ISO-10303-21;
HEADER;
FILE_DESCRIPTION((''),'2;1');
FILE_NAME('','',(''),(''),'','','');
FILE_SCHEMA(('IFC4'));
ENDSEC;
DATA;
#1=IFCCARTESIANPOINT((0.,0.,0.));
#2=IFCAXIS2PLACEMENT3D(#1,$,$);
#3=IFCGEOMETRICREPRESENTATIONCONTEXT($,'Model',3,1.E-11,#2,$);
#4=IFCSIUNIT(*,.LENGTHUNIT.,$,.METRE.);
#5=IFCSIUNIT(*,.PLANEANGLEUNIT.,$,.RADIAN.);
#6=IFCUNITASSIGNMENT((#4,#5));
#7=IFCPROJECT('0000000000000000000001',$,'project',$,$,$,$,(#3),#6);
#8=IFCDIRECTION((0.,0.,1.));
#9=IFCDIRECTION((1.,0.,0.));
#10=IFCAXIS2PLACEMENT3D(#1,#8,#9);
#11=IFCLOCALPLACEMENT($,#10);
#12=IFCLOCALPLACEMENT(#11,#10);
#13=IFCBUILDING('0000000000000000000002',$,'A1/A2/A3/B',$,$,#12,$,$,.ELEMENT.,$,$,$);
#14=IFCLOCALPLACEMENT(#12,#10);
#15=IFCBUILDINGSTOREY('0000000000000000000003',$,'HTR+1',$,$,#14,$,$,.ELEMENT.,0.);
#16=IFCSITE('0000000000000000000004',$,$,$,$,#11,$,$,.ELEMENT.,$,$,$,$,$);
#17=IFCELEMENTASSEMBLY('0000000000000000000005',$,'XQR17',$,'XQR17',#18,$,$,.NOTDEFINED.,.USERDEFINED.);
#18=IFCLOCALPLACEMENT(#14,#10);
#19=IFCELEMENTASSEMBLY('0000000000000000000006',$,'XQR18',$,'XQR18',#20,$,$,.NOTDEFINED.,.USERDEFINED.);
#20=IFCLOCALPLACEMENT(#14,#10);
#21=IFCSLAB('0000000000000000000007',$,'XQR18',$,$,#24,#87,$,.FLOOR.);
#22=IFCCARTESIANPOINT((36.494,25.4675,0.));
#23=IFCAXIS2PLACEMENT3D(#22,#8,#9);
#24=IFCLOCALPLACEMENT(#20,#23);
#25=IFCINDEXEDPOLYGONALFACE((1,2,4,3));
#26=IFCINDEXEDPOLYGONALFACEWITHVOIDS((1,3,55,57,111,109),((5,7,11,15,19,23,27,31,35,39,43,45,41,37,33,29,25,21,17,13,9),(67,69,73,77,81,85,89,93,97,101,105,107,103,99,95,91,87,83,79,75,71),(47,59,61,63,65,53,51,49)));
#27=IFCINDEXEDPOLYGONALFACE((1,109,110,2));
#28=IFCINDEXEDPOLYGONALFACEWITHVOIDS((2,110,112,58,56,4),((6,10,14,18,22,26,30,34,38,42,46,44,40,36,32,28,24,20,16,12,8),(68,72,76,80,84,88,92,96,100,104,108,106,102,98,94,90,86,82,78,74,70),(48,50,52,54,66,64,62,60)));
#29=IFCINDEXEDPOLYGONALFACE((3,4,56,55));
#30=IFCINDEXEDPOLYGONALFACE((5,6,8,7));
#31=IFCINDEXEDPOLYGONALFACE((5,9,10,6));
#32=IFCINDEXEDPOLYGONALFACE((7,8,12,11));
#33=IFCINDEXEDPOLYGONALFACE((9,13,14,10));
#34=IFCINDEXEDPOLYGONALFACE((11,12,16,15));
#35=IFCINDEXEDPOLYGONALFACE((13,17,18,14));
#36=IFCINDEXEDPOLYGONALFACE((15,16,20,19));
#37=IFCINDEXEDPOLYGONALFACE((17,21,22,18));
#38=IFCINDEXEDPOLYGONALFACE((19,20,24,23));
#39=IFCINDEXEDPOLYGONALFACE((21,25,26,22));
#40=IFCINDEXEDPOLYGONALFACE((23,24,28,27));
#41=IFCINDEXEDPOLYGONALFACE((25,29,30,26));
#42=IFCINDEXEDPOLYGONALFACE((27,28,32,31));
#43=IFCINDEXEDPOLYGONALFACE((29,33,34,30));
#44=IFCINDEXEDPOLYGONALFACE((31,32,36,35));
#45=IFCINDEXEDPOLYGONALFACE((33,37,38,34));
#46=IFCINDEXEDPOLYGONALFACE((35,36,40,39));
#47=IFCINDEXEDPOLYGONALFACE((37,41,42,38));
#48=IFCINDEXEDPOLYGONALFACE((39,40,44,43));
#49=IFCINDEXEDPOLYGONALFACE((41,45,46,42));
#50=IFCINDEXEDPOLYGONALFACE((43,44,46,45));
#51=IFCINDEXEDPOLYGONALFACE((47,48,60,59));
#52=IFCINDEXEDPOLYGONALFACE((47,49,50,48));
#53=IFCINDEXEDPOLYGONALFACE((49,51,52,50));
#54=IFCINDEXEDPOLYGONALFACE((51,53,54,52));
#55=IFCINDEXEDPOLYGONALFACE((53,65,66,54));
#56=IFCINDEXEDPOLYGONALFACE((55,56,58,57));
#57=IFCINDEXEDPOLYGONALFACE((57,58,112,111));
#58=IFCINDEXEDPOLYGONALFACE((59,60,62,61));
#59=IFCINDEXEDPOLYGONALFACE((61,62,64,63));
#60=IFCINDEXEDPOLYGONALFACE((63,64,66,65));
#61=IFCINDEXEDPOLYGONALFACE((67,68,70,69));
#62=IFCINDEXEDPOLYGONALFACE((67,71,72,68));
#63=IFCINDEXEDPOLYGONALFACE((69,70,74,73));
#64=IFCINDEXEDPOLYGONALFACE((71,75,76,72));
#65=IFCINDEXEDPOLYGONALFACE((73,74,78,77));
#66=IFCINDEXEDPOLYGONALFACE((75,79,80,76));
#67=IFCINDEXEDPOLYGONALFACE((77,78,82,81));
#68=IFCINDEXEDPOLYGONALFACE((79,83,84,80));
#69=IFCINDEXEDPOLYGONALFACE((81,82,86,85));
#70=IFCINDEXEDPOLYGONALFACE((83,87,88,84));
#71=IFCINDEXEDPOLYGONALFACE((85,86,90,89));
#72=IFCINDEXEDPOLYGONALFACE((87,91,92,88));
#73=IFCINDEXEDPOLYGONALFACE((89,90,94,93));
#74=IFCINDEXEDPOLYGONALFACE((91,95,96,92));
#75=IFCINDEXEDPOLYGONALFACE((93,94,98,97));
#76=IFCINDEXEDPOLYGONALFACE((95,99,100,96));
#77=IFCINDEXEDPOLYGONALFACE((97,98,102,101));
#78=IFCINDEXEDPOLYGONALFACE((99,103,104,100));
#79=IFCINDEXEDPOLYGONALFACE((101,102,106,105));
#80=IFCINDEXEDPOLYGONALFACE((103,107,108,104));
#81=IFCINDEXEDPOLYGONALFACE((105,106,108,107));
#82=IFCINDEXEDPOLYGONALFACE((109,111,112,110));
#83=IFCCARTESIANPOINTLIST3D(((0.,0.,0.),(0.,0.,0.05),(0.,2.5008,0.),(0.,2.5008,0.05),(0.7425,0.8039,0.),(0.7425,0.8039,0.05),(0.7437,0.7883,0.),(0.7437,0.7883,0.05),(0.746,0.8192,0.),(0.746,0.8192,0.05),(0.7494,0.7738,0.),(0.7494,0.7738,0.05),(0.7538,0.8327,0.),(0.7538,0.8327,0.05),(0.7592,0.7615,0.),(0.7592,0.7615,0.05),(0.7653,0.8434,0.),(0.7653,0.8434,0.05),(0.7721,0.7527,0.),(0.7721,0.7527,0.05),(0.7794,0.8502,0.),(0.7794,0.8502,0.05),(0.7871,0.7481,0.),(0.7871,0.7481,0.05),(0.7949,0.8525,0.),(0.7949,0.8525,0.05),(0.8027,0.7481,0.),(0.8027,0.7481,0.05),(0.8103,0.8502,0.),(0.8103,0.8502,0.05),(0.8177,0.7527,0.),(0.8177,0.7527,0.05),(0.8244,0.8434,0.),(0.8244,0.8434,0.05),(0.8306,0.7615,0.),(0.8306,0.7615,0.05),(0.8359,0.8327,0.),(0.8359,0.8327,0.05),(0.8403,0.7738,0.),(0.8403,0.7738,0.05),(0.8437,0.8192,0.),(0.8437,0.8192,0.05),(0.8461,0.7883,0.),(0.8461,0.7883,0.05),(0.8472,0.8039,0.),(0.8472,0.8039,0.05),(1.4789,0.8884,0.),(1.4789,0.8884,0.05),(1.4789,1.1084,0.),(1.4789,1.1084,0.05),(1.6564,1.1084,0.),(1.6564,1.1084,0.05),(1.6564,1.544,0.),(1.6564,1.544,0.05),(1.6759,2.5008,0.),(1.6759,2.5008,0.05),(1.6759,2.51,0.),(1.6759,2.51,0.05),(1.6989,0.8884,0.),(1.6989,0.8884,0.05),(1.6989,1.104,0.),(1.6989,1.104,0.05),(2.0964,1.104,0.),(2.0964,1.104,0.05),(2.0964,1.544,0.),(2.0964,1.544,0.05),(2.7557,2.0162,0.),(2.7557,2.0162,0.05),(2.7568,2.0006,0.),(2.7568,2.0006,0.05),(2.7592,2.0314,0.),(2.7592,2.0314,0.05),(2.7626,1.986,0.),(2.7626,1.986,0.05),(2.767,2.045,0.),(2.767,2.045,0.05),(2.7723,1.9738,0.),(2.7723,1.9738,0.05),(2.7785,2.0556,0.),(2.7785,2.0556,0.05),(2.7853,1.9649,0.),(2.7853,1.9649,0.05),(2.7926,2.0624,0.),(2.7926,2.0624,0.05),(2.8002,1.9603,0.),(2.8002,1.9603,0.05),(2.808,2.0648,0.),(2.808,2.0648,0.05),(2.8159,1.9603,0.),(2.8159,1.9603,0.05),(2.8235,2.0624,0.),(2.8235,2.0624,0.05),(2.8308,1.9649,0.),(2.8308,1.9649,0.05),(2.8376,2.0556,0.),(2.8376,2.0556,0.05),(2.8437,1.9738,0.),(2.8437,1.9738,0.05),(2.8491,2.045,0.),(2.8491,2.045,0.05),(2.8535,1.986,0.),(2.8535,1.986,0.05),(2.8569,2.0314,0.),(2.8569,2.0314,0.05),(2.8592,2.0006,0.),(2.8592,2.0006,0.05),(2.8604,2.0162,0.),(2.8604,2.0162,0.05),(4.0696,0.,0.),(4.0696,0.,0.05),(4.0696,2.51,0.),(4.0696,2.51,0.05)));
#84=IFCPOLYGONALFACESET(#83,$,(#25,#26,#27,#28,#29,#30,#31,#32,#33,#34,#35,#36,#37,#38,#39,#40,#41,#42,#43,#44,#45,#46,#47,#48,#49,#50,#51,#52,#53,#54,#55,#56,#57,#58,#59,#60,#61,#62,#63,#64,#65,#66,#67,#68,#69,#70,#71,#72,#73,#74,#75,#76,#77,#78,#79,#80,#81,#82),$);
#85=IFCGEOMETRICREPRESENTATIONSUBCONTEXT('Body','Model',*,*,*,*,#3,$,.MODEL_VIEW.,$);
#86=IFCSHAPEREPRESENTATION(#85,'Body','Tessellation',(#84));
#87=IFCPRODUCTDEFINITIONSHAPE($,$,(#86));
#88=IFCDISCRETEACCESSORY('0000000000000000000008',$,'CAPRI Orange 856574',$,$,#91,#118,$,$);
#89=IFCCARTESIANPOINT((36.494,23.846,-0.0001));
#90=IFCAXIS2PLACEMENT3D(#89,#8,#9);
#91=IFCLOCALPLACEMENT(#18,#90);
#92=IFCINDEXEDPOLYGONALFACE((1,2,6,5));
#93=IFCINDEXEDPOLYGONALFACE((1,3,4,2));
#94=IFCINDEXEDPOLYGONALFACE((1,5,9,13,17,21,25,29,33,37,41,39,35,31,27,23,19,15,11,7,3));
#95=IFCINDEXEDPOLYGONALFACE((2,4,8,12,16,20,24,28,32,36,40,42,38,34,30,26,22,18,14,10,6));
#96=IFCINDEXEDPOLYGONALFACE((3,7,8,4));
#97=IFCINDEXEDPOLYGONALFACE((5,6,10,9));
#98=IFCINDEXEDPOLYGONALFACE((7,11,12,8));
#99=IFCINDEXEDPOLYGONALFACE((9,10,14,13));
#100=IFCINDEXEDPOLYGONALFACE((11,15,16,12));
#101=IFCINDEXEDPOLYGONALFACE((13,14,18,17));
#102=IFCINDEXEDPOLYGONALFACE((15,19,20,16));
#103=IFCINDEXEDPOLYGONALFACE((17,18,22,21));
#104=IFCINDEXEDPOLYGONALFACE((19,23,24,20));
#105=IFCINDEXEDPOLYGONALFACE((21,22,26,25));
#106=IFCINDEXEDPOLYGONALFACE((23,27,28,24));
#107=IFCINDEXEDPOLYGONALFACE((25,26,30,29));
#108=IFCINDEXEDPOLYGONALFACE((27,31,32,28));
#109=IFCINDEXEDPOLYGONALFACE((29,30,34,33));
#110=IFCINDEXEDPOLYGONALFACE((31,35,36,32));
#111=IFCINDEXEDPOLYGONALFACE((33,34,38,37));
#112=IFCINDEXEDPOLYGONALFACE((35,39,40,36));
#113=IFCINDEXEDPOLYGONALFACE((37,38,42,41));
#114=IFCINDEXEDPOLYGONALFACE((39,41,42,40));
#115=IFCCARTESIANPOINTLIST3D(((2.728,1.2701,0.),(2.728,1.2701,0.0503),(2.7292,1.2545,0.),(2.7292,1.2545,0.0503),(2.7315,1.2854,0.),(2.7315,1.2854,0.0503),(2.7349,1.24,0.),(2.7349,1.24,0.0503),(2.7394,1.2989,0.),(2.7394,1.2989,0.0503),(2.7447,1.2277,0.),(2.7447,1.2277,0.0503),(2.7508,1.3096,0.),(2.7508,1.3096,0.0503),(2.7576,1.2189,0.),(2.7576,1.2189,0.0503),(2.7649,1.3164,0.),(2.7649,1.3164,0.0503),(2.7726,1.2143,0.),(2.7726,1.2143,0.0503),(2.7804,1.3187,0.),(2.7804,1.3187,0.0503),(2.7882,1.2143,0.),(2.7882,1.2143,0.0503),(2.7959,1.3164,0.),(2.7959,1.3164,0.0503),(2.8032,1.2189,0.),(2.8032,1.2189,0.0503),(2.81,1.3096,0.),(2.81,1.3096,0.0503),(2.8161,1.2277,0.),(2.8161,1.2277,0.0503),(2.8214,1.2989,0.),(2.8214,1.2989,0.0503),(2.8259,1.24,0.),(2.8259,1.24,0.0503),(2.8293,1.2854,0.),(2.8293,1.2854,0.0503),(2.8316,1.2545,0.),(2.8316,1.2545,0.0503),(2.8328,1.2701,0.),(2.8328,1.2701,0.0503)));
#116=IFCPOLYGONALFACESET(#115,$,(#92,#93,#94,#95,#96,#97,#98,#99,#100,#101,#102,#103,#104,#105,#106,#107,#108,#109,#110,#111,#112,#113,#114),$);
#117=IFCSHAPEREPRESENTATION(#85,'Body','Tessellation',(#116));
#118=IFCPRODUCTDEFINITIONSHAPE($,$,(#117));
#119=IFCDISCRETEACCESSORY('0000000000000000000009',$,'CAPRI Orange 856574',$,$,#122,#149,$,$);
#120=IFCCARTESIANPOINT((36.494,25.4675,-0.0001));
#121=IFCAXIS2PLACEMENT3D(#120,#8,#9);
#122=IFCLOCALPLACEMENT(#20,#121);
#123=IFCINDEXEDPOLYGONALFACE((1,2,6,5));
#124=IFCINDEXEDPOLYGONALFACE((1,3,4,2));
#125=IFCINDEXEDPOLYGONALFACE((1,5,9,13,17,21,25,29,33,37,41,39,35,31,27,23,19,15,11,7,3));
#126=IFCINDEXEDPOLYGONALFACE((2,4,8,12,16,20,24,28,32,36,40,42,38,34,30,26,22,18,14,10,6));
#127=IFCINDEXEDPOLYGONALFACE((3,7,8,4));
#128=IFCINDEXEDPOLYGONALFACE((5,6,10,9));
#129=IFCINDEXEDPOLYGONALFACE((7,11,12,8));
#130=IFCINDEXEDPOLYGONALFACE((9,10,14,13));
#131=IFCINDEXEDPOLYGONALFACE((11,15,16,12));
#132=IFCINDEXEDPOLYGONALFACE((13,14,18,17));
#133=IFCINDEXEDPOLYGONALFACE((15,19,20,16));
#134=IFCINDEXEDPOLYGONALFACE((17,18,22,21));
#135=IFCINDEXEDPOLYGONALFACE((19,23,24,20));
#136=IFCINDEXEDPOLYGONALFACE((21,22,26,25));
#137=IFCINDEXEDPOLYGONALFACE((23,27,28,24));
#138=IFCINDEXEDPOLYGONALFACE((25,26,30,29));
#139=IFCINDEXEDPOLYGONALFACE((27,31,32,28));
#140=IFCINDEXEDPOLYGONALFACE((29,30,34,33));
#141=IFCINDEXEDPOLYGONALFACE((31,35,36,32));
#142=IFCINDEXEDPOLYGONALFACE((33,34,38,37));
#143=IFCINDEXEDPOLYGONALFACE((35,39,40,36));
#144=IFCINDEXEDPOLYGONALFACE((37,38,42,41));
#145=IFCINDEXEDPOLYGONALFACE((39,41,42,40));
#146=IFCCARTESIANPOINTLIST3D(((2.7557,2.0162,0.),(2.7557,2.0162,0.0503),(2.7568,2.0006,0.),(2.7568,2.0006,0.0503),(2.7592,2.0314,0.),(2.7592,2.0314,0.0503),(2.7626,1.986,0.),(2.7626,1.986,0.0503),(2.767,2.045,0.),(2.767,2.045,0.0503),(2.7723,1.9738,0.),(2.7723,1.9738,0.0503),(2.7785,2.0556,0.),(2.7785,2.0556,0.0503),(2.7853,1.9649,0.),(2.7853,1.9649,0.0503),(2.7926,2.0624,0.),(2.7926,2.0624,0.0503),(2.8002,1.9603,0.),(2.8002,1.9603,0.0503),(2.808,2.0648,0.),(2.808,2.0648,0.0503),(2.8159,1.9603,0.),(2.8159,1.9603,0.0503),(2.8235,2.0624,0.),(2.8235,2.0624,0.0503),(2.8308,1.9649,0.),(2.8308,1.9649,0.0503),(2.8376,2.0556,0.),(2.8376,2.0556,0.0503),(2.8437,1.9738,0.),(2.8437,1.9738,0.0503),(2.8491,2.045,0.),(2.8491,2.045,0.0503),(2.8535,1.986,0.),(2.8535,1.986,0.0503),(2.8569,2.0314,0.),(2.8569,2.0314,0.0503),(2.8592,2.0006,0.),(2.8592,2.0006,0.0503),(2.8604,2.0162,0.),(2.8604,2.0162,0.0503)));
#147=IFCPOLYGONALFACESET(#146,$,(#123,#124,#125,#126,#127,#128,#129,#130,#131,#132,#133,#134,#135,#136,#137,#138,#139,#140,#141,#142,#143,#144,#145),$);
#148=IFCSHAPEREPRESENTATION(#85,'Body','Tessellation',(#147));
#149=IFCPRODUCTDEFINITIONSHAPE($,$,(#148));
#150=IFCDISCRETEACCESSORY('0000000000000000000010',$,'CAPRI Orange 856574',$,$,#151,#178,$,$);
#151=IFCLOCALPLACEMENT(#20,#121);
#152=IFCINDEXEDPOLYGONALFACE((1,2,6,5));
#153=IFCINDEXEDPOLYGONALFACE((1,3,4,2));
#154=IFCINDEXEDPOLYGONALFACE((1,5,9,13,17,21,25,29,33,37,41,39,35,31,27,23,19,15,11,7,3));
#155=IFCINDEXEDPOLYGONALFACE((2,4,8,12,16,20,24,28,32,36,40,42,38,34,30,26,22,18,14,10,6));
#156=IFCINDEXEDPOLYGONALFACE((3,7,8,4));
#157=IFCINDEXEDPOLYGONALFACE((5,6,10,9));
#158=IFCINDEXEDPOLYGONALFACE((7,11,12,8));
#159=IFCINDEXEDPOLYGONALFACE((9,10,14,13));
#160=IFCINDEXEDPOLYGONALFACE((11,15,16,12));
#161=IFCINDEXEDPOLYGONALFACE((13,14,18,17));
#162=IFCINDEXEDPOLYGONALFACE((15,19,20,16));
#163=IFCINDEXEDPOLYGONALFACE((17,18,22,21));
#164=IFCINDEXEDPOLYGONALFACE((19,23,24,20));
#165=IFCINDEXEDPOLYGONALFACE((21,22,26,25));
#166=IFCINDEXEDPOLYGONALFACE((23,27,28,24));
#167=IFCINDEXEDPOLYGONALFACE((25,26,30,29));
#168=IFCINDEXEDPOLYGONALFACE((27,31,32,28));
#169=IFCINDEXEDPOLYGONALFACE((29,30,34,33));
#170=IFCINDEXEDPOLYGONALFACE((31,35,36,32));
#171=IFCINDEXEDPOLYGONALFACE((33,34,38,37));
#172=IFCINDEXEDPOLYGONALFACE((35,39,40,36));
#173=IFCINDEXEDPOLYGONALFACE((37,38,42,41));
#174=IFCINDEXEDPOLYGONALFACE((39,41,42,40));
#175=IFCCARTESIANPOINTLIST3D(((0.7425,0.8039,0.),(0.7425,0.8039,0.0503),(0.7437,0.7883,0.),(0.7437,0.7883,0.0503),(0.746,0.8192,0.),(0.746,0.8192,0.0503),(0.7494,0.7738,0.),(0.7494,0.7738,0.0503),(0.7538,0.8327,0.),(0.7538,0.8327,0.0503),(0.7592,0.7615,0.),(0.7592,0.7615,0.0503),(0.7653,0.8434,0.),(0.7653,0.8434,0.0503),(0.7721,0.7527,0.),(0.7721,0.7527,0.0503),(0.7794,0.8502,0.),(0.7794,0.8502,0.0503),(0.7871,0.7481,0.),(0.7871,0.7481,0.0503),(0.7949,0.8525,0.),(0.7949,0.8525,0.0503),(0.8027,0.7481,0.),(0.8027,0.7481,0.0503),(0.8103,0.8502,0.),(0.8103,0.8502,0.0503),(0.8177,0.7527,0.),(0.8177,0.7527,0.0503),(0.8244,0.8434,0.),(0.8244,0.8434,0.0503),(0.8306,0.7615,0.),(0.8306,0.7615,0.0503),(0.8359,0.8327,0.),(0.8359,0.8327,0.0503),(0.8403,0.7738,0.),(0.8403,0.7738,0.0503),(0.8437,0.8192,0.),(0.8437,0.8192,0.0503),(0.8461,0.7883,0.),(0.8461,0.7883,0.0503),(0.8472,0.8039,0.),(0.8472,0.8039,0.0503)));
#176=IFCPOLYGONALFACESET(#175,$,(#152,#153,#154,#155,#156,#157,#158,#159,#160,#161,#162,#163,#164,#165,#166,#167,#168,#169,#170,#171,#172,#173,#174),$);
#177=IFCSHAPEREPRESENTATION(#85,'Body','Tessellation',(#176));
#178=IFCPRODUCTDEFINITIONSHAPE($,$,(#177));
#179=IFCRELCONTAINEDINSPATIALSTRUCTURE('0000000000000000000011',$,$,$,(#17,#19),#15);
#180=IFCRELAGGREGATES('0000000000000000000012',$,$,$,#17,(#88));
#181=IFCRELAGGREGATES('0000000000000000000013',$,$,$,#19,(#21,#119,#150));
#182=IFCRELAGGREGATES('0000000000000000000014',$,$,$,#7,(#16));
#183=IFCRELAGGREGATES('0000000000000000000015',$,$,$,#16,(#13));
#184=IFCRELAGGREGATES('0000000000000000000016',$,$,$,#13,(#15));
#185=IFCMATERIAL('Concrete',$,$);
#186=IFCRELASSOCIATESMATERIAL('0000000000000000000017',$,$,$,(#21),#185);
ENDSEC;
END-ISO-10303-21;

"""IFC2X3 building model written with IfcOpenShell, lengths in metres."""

from ifc_helpers import new_model, si_unit, frame, frame_2d, origin, origin_with_axes, origin_2d_with_axis, place, context, subcontext, project, spatial, polyline, circle, outline, extrude, material, element, aggregate, save


model = new_model("IFC2X3")

# Units and contexts
model_context = context("Model", 3, precision=1e-11, world=origin())
body_context = subcontext(model_context, "Body", "Model", "MODEL_VIEW")
ifc_project = project(units=[si_unit("LENGTHUNIT", "METRE"), si_unit("PLANEANGLEUNIT", "RADIAN")], contexts=[model_context])

# Site, building, storey
site_placement = place(None, origin_with_axes())
site = spatial("IfcSite", under=ifc_project, at=site_placement, CompositionType="ELEMENT")
building_placement = place(site_placement, origin_with_axes())
building = spatial("IfcBuilding", under=site, at=building_placement, Name="A1/A2/A3/B", CompositionType="ELEMENT")
storey_placement = place(building_placement, origin_with_axes())
storey = spatial("IfcBuildingStorey", under=building, at=storey_placement, Name="HTR+1", CompositionType="ELEMENT", Elevation=0.0)

# Element assembly
assembly_1_placement = place(storey_placement, origin_with_axes())
assembly_1 = element("IfcElementAssembly", 1, at=assembly_1_placement, inside=storey, Name="XQR17", ObjectType="XQR17", AssemblyPlace="NOTDEFINED", PredefinedType="USERDEFINED")
ifc_material = material(Name="Concrete")

# Element assembly, slab, openings
assembly_2_placement = place(storey_placement, origin_with_axes())
assembly_2 = element("IfcElementAssembly", 2, at=assembly_2_placement, inside=storey, Name="XQR18", ObjectType="XQR18", AssemblyPlace="NOTDEFINED", PredefinedType="USERDEFINED")
slab_1_placement = place(assembly_2_placement, frame((36.494, 25.4675, 0.0), z_axis=(0.0, 0.0, 1.0), x_axis=(1.0, 0.0, 0.0)))
slab_1 = element("IfcSlab", 3, at=slab_1_placement, material=ifc_material, Name="XQR18", PredefinedType="FLOOR", context=body_context, shape_type="SweptSolid", body=[
    extrude(outline(polyline([(0.0, 0.0), (0.0, -4.0696), (2.51, -4.0696), (2.51, -1.6759), (2.5008, -1.6759), (2.5008, 0.0), (0.0, 0.0)])), frame((0.0, 0.0, 0.0), z_axis=(0.0, 0.0, 1.0), x_axis=(0.0, 1.0, 0.0)), (0.0, 0.0, 1.0), 0.05),
])
opening_1_placement = place(slab_1_placement, origin_with_axes())
element("IfcOpeningElement", 4, at=opening_1_placement, cuts=slab_1, ObjectType="Opening", context=body_context, shape_type="SweptSolid", body=[
    extrude(outline(polyline([(1.104, -1.6564), (1.104, -2.0964), (1.544, -2.0964), (1.544, -1.6564), (1.104, -1.6564)])), frame((0.0, 0.0, 0.0), z_axis=(0.0, 0.0, 1.0), x_axis=(0.0, 1.0, 0.0)), (0.0, 0.0, 1.0), 0.05),
])
opening_2_placement = place(slab_1_placement, origin_with_axes())
element("IfcOpeningElement", 5, at=opening_2_placement, cuts=slab_1, ObjectType="Opening", context=body_context, shape_type="SweptSolid", body=[
    extrude(outline(polyline([(0.8884, -1.4789), (0.8884, -1.6989), (1.1084, -1.6989), (1.1084, -1.4789), (0.8884, -1.4789)])), frame((0.0, 0.0, 0.0), z_axis=(0.0, 0.0, 1.0), x_axis=(0.0, 1.0, 0.0)), (0.0, 0.0, 1.0), 0.05),
])
opening_3_placement = place(slab_1_placement, frame((2.808, 2.0122, 0.0), z_axis=(0.0, 0.0, 1.0), x_axis=(1.0, 0.0, 0.0)))
element("IfcOpeningElement", 6, at=opening_3_placement, cuts=slab_1, ObjectType="Opening", context=body_context, shape_type="SweptSolid", body=[
    extrude(circle(Radius=0.0525, at=origin_2d_with_axis()), frame((0.0, 0.0, 0.0), z_axis=(0.0, 0.0, 1.0), x_axis=(0.0, 1.0, 0.0)), (0.0, 0.0, 1.0), 0.05),
])
opening_4_placement = place(slab_1_placement, frame((0.7949, 0.8, 0.0), z_axis=(0.0, 0.0, 1.0), x_axis=(1.0, 0.0, 0.0)))
element("IfcOpeningElement", 7, at=opening_4_placement, cuts=slab_1, ObjectType="Opening", context=body_context, shape_type="SweptSolid", body=[
    extrude(circle(Radius=0.0525, at=origin_2d_with_axis()), frame((0.0, 0.0, 0.0), z_axis=(0.0, 0.0, 1.0), x_axis=(0.0, 1.0, 0.0)), (0.0, 0.0, 1.0), 0.05),
])

# Discrete accessory
discrete_accessory_1_placement = place(assembly_1_placement, frame((36.494, 23.846, -0.0001), z_axis=(0.0, 0.0, 1.0), x_axis=(1.0, 0.0, 0.0)))
discrete_accessory_1 = element("IfcDiscreteAccessory", 8, at=discrete_accessory_1_placement, Name="CAPRI Orange 856574", context=body_context, shape_type="SweptSolid", body=[
    extrude(circle(Radius=0.0525, at=frame_2d((1.2662, -2.7804), x_axis=(1.0, 0.0))), frame((0.0, 0.0, 0.0), z_axis=(0.0, 0.0, 1.0), x_axis=(0.0, 1.0, 0.0)), (0.0, 0.0, 1.0), 0.0503),
])

aggregate(assembly_1, [discrete_accessory_1])

# Discrete accessories
discrete_accessory_2_placement = place(assembly_2_placement, frame((36.494, 25.4675, -0.0001), z_axis=(0.0, 0.0, 1.0), x_axis=(1.0, 0.0, 0.0)))
discrete_accessory_2 = element("IfcDiscreteAccessory", 9, at=discrete_accessory_2_placement, Name="CAPRI Orange 856574", context=body_context, shape_type="SweptSolid", body=[
    extrude(circle(Radius=0.0525, at=frame_2d((2.0122, -2.808), x_axis=(1.0, 0.0))), frame((0.0, 0.0, 0.0), z_axis=(0.0, 0.0, 1.0), x_axis=(0.0, 1.0, 0.0)), (0.0, 0.0, 1.0), 0.0503),
])
discrete_accessory_3_placement = place(assembly_2_placement, frame((36.494, 25.4675, -0.0001), z_axis=(0.0, 0.0, 1.0), x_axis=(1.0, 0.0, 0.0)))
discrete_accessory_3 = element("IfcDiscreteAccessory", 10, at=discrete_accessory_3_placement, Name="CAPRI Orange 856574", context=body_context, shape_type="SweptSolid", body=[
    extrude(circle(Radius=0.0525, at=frame_2d((0.8, -0.7949), x_axis=(1.0, 0.0))), frame((0.0, 0.0, 0.0), z_axis=(0.0, 0.0, 1.0), x_axis=(0.0, 1.0, 0.0)), (0.0, 0.0, 1.0), 0.0503),
])

aggregate(assembly_2, [slab_1, discrete_accessory_2, discrete_accessory_3])

save(model, "model.ifc")
